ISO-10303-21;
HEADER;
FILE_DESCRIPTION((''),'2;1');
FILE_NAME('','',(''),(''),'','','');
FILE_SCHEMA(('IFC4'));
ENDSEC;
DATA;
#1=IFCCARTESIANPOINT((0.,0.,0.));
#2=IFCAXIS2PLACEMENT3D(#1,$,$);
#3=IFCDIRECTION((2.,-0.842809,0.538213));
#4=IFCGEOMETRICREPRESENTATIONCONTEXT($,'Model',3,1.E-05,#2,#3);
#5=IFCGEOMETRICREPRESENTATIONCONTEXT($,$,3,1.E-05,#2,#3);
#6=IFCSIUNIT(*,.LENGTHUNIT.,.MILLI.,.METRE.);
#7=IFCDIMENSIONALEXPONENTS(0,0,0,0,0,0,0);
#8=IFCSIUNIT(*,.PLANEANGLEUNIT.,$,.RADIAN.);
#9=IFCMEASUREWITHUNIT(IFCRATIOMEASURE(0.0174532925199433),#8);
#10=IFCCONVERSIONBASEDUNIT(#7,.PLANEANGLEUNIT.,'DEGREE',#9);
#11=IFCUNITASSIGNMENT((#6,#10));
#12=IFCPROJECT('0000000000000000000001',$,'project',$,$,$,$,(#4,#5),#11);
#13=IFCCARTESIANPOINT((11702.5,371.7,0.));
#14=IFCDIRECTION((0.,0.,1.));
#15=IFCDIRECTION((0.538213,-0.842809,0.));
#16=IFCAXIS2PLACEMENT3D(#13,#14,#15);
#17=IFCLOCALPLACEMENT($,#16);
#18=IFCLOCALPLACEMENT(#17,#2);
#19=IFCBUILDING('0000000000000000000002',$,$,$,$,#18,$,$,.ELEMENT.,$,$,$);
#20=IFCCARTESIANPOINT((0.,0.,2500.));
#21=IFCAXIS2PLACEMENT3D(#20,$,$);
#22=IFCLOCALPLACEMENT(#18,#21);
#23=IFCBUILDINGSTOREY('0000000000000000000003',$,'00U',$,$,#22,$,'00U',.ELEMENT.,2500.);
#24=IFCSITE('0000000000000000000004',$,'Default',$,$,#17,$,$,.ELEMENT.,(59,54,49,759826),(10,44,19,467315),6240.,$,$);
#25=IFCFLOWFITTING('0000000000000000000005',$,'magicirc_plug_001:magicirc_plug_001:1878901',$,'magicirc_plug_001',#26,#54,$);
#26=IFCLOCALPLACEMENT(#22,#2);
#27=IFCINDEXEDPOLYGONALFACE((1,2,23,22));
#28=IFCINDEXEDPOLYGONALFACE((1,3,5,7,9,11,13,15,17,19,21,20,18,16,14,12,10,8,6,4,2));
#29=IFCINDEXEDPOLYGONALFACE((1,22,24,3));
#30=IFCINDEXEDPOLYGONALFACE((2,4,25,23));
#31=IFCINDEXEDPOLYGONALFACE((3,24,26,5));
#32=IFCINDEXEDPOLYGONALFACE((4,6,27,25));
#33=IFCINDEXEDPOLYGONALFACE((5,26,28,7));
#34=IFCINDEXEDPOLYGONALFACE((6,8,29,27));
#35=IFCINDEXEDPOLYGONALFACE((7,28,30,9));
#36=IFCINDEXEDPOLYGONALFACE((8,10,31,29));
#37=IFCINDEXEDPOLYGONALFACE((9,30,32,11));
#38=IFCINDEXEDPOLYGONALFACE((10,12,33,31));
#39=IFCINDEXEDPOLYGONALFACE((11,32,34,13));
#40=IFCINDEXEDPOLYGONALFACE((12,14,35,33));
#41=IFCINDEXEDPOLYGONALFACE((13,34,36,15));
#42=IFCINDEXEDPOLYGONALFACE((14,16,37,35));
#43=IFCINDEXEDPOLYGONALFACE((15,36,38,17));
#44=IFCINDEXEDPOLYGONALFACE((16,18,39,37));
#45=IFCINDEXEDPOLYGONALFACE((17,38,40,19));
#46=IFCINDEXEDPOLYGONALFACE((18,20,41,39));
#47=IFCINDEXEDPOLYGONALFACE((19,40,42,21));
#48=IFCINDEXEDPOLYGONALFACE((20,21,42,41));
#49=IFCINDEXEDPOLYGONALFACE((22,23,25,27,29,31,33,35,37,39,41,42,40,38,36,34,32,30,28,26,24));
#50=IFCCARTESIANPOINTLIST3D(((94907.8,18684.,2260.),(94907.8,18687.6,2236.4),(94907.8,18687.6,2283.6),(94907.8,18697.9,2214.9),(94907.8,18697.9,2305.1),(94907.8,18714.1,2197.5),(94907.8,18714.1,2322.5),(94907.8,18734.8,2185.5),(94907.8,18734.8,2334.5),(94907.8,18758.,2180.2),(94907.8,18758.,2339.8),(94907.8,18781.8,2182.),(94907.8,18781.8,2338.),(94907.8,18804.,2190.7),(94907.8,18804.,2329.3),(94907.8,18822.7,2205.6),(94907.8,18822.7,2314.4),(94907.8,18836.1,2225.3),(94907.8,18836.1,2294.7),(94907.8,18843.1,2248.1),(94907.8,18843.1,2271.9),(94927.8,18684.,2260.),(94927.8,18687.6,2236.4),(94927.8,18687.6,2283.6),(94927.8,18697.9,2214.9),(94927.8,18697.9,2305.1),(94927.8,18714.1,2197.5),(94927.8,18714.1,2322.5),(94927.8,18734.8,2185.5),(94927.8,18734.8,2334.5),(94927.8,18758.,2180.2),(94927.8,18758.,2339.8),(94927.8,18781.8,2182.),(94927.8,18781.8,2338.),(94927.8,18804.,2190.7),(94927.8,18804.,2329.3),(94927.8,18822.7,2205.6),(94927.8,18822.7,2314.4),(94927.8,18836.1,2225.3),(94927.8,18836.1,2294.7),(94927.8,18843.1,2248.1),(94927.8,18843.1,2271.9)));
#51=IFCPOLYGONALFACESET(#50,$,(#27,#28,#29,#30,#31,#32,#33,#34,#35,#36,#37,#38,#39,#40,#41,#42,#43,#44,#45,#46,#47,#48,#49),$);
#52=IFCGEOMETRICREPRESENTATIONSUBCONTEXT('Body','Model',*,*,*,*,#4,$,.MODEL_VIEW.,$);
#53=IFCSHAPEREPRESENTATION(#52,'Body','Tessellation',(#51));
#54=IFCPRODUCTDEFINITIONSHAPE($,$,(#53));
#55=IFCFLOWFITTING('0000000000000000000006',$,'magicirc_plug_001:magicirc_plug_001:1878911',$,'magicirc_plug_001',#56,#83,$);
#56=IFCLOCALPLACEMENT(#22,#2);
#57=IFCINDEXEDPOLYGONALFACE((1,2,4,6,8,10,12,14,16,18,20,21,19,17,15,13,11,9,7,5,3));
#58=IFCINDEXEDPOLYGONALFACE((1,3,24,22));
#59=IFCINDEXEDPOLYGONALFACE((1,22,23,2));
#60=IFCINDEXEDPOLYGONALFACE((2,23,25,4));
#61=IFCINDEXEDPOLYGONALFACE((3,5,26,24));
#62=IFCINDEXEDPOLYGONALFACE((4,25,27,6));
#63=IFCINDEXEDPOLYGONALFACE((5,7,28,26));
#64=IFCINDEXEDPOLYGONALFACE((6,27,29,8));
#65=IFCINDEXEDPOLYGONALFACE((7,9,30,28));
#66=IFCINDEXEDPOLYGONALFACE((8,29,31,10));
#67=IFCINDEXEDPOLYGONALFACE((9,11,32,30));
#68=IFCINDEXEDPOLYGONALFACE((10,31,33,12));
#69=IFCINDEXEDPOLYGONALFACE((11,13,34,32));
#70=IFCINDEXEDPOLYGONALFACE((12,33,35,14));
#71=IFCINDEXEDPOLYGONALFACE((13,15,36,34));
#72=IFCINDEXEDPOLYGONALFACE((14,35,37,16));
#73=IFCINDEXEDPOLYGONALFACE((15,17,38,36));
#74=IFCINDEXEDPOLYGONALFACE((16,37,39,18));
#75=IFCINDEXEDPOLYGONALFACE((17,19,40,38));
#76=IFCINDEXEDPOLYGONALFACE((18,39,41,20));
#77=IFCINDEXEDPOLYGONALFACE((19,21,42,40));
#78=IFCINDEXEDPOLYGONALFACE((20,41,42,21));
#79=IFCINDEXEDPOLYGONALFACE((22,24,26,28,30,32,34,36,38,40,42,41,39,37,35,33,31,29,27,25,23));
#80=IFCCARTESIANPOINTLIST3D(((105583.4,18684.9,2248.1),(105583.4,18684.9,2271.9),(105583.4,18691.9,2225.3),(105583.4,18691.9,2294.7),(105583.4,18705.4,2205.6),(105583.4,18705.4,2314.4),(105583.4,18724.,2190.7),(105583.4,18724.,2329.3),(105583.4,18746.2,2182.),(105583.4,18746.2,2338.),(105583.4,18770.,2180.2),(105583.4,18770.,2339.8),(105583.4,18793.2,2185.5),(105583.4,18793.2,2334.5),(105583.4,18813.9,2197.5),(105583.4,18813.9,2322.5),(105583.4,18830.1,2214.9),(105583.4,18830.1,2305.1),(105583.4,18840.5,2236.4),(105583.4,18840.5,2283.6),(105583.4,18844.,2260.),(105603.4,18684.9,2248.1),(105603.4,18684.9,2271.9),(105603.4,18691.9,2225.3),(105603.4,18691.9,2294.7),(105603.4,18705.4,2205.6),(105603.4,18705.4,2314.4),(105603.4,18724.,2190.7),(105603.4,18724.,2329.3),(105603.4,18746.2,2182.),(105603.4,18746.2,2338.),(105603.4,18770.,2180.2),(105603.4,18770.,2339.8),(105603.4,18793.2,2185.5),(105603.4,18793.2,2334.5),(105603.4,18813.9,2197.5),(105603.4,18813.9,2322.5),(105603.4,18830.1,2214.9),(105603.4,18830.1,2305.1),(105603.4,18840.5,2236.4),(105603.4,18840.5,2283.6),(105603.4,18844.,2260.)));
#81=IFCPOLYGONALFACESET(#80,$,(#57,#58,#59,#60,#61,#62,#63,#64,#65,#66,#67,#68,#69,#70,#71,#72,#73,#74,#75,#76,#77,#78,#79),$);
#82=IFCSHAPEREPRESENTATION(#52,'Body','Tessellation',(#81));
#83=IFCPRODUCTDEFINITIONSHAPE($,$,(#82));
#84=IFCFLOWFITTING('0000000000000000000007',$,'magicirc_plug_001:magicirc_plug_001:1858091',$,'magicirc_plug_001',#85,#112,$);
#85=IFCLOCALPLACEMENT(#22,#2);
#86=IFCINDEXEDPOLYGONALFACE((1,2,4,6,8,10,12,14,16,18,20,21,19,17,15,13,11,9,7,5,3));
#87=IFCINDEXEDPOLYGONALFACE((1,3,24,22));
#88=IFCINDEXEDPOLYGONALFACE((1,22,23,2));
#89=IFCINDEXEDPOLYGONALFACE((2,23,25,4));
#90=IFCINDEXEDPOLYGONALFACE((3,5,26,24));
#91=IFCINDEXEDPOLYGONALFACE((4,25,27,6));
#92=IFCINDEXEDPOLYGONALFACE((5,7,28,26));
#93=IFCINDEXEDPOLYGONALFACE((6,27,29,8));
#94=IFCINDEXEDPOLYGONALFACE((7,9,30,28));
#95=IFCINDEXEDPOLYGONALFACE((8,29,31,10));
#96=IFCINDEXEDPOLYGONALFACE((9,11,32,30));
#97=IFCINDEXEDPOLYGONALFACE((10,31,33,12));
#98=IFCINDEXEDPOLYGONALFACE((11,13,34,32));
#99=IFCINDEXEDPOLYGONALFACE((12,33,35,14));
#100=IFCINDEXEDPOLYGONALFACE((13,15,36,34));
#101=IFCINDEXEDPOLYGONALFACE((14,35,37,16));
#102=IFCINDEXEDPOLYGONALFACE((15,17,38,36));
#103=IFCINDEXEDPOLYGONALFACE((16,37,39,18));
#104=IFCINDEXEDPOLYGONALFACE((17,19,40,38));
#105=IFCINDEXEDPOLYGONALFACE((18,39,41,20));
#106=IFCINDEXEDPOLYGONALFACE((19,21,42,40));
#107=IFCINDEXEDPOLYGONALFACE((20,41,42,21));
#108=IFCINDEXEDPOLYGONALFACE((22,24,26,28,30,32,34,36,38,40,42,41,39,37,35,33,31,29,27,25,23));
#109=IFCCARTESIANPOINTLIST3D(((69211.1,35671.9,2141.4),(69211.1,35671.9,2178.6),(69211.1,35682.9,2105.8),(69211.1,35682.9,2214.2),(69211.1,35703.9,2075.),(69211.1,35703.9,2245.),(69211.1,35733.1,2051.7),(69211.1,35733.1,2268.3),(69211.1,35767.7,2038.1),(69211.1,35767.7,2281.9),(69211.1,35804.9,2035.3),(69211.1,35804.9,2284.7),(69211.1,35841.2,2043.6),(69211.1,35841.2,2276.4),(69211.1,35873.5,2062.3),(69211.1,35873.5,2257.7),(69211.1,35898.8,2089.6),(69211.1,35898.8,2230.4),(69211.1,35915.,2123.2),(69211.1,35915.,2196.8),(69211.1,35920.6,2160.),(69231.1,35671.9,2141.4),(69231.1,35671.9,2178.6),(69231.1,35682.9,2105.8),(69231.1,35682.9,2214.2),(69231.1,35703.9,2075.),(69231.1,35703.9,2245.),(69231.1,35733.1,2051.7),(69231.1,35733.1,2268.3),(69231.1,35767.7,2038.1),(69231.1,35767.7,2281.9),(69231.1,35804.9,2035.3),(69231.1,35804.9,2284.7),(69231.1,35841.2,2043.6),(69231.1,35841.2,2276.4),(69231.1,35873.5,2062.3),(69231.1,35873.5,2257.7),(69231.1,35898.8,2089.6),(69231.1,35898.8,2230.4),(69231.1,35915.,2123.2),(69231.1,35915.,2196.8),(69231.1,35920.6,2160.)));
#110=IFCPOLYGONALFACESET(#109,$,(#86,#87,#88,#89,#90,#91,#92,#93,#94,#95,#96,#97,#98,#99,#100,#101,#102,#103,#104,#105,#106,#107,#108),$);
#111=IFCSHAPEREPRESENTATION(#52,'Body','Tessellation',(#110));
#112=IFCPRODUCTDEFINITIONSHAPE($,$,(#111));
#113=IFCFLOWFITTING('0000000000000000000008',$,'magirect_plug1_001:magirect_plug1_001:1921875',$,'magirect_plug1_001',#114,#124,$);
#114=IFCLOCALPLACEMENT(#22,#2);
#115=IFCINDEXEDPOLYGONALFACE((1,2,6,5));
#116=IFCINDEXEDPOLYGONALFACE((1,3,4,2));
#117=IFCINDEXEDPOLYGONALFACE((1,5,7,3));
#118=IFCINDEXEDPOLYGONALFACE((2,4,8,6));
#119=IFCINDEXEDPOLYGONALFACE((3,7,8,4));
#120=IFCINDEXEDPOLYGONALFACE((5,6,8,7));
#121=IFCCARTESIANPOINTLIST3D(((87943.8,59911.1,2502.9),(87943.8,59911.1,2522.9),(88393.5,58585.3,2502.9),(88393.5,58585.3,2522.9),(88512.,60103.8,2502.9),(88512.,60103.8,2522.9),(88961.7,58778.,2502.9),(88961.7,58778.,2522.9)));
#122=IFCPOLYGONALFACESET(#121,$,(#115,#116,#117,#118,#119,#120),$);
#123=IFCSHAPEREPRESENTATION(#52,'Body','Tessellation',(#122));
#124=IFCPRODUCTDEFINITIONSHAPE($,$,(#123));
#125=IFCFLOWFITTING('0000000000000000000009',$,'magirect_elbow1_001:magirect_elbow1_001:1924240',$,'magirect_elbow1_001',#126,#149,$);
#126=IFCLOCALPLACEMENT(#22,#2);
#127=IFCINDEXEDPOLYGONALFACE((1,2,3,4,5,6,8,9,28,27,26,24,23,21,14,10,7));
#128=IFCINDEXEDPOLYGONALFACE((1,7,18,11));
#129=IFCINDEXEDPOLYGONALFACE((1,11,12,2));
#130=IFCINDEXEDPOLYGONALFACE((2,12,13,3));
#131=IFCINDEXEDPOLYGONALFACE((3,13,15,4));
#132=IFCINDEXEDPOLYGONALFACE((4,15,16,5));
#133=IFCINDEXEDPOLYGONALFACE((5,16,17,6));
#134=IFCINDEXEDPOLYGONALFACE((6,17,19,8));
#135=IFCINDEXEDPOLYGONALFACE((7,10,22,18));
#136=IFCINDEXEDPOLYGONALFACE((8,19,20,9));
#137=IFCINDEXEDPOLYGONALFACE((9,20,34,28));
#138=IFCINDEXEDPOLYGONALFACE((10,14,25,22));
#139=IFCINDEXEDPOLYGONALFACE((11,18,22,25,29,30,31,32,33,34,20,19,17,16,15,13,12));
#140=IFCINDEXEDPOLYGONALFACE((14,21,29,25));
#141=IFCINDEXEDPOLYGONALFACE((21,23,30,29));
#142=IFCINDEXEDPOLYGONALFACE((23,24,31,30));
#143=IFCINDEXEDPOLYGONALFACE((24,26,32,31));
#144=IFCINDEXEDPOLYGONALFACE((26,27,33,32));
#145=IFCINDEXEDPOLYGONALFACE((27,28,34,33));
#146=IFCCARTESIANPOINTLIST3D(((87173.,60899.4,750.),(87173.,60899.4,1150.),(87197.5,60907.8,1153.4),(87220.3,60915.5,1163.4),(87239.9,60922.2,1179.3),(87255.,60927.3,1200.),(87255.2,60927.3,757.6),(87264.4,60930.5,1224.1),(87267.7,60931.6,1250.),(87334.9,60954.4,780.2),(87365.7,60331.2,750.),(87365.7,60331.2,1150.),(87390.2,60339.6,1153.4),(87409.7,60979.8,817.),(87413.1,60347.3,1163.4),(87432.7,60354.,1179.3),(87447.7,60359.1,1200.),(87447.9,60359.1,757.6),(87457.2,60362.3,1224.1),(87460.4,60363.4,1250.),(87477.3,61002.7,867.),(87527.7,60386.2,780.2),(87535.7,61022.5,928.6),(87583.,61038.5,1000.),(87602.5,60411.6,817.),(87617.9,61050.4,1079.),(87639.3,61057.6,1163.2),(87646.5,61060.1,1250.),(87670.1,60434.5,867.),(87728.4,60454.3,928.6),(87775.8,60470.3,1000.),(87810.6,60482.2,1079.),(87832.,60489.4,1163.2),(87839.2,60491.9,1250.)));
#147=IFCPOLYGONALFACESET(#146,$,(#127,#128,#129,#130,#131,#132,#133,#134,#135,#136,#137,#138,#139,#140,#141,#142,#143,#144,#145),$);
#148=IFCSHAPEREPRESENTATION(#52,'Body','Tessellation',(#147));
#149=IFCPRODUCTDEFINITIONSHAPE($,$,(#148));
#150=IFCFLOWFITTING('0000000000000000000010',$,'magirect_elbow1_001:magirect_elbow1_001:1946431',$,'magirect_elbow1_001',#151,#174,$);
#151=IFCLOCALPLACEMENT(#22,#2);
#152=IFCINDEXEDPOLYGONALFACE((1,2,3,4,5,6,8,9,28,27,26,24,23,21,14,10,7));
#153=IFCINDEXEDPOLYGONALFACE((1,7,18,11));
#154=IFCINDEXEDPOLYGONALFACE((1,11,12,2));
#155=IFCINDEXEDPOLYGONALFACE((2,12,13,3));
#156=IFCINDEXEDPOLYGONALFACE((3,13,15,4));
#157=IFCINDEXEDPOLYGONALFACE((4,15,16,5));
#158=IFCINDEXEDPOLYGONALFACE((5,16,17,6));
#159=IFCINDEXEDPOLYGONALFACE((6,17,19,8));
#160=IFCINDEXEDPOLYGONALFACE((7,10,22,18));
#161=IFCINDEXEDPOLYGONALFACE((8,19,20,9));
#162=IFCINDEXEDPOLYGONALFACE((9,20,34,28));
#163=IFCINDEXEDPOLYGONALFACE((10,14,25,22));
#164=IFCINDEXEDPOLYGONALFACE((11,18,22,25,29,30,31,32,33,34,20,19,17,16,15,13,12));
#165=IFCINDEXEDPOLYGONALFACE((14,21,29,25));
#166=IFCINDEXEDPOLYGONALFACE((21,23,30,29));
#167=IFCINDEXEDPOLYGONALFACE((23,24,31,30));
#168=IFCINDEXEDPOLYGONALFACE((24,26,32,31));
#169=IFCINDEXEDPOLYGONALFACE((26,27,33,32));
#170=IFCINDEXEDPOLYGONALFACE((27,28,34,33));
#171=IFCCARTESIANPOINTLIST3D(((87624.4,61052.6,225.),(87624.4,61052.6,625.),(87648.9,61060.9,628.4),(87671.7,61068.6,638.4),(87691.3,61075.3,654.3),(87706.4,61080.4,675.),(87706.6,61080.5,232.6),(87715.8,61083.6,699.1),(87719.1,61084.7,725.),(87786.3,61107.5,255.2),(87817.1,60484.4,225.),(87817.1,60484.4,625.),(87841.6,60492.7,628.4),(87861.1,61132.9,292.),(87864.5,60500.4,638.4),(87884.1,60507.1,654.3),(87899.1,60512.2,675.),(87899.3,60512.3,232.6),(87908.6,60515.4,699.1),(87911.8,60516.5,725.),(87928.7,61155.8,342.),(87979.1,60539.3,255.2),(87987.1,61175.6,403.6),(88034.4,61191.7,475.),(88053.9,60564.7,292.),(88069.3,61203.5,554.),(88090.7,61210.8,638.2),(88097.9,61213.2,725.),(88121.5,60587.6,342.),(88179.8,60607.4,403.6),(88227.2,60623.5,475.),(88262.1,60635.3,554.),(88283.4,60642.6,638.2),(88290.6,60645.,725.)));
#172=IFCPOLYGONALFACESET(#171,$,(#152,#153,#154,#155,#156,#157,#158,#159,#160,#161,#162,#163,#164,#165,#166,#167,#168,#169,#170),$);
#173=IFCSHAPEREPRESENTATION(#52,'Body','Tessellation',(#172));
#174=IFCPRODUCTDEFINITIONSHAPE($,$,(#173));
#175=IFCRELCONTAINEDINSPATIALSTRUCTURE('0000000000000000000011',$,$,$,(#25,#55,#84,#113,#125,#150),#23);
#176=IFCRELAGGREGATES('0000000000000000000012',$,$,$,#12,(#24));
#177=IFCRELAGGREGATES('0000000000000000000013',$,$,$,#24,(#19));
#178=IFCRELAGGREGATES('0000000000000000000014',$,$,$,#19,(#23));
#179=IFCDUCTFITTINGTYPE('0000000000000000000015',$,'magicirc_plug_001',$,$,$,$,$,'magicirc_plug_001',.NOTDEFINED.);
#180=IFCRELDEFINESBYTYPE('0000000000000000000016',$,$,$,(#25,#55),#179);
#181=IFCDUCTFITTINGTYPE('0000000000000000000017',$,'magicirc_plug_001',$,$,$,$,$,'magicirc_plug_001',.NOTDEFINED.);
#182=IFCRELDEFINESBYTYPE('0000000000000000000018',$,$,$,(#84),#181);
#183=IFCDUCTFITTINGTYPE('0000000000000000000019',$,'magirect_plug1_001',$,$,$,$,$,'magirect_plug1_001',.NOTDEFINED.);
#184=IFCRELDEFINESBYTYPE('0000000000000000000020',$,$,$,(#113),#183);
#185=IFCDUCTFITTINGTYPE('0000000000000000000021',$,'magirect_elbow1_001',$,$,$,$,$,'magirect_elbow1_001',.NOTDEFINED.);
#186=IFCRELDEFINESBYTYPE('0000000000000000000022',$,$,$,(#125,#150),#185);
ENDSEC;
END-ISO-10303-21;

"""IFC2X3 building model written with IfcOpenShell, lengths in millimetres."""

from ifc_helpers import new_model, entity, si_unit, converted_unit, direction, frame, frame_2d, origin, place, context, subcontext, project, spatial, polyline, circle_curve, parameter, trimmed, segment, composite_curve, rectangle, circle, outline, extrude, source, transform, mapped, type_object, type_shapes, element, save


model = new_model("IFC2X3")

# Units and contexts
model_context = context("Model", 3, precision=1e-05, world=origin(), true_north=direction((2.0, -0.842809, 0.538213)))
context_of_model = context(None, 3, precision=1e-05, world=origin(), true_north=direction((2.0, -0.842809, 0.538213)))
body_context = subcontext(model_context, "Body", "Model", "MODEL_VIEW")
ifc_project = project(units=[si_unit("LENGTHUNIT", "METRE", prefix="MILLI"), converted_unit("PLANEANGLEUNIT", "DEGREE", entity("IfcRatioMeasure", 0.0174532925199433), si_unit("PLANEANGLEUNIT", "RADIAN"), dimensions=[0, 0, 0, 0, 0, 0, 0])], contexts=[model_context, context_of_model])

# Site, building, storey
site_placement = place(None, frame((11702.5, 371.7, 0.0), z_axis=(0.0, 0.0, 1.0), x_axis=(0.538213, -0.842809, 0.0)))
site = spatial("IfcSite", under=ifc_project, at=site_placement, Name="Default", CompositionType="ELEMENT", RefLatitude=(59, 54, 49, 759826), RefLongitude=(10, 44, 19, 467315), RefElevation=6240.0)
building_placement = place(site_placement, origin())
building = spatial("IfcBuilding", under=site, at=building_placement, CompositionType="ELEMENT")
storey_placement = place(building_placement, frame((0.0, 0.0, 2500.0)))
storey = spatial("IfcBuildingStorey", under=building, at=storey_placement, Name="00U", LongName="00U", CompositionType="ELEMENT", Elevation=2500.0)

# Flow fittings
duct_fitting_type_1 = type_object("IfcDuctFittingType", Name="magicirc_plug_001", ElementType="magicirc_plug_001", PredefinedType="NOTDEFINED")
shared_shape_1 = source(origin(), body_context, "Body", "SweptSolid", [
    extrude(circle(Radius=80.0, at=frame_2d((0.0, 0.0), x_axis=(1.0, 0.0))), frame((0.0, 0.0, 0.0), z_axis=(1.0, 0.0, 0.0), x_axis=(0.0, 1.0, 0.0)), (0.0, 0.0, 1.0), 20.0),
])
type_shapes(duct_fitting_type_1, [shared_shape_1])
flow_fitting_1_placement = place(storey_placement, frame((94927.8, 18764.0, 2260.0), z_axis=(0.0, 0.0, 1.0), x_axis=(-1.0, 0.0, 0.0)))
element("IfcFlowFitting", 1, at=flow_fitting_1_placement, inside=storey, type_object=duct_fitting_type_1, Name="magicirc_plug_001:magicirc_plug_001:1878901", ObjectType="magicirc_plug_001", context=body_context, shape_type="MappedRepresentation", body=[
    mapped(shared_shape_1, transform((0.0, 0.0, 0.0), scale=1.0)),
])
flow_fitting_2_placement = place(storey_placement, frame((105583.4, 18764.0, 2260.0)))
element("IfcFlowFitting", 2, at=flow_fitting_2_placement, inside=storey, type_object=duct_fitting_type_1, Name="magicirc_plug_001:magicirc_plug_001:1878911", ObjectType="magicirc_plug_001", context=body_context, shape_type="MappedRepresentation", body=[
    mapped(shared_shape_1, transform((0.0, 0.0, 0.0), scale=1.0)),
])
duct_fitting_type_2 = type_object("IfcDuctFittingType", Name="magicirc_plug_001", ElementType="magicirc_plug_001", PredefinedType="NOTDEFINED")
shared_shape_2 = source(origin(), body_context, "Body", "SweptSolid", [
    extrude(circle(Radius=125.0, at=frame_2d((0.0, 0.0), x_axis=(1.0, 0.0))), frame((0.0, 0.0, 0.0), z_axis=(1.0, 0.0, 0.0), x_axis=(0.0, 1.0, 0.0)), (0.0, 0.0, 1.0), 20.0),
])
type_shapes(duct_fitting_type_2, [shared_shape_2])
flow_fitting_3_placement = place(storey_placement, frame((69211.1, 35795.6, 2160.0)))
element("IfcFlowFitting", 3, at=flow_fitting_3_placement, inside=storey, type_object=duct_fitting_type_2, Name="magicirc_plug_001:magicirc_plug_001:1858091", ObjectType="magicirc_plug_001", context=body_context, shape_type="MappedRepresentation", body=[
    mapped(shared_shape_2, transform((0.0, 0.0, 0.0), scale=1.0)),
])
duct_fitting_type_3 = type_object("IfcDuctFittingType", Name="magirect_plug1_001", ElementType="magirect_plug1_001", PredefinedType="NOTDEFINED")
shared_shape_3 = source(origin(), body_context, "Body", "SweptSolid", [
    extrude(rectangle(XDim=20.0, YDim=1400.0, at=frame_2d((0.0, 0.0), x_axis=(1.0, 0.0))), frame((10.0, 0.0, -300.0)), (0.0, 0.0, 1.0), 600.0),
])
type_shapes(duct_fitting_type_3, [shared_shape_3])
flow_fitting_4_placement = place(storey_placement, frame((88452.8, 59344.5, 2502.9), z_axis=(-0.946996, -0.321246, 0.0), x_axis=(0.0, 0.0, 1.0)))
element("IfcFlowFitting", 4, at=flow_fitting_4_placement, inside=storey, type_object=duct_fitting_type_3, Name="magirect_plug1_001:magirect_plug1_001:1921875", ObjectType="magirect_plug1_001", context=body_context, shape_type="MappedRepresentation", body=[
    mapped(shared_shape_3, transform((0.0, 0.0, 0.0), scale=1.0)),
])
duct_fitting_type_4 = type_object("IfcDuctFittingType", Name="magirect_elbow1_001", ElementType="magirect_elbow1_001", PredefinedType="NOTDEFINED")
shared_shape_4 = source(origin(), body_context, "Body", "SweptSolid", [
    extrude(outline(composite_curve([segment(polyline([(-350.0, -150.0), (50.0, -150.0)]), True, "CONTINUOUS"), segment(trimmed(circle_curve(frame_2d((150.0, -150.0), x_axis=(0.0, 1.0)), 100.0), [parameter(0.0)], [parameter(90.0)], True, "PARAMETER"), False, "CONTINUOUS"), segment(polyline([(150.0, -50.0), (150.0, 350.0)]), True, "CONTINUOUS"), segment(trimmed(circle_curve(frame_2d((150.0, -150.0), x_axis=(0.0, 1.0)), 500.0), [parameter(0.0)], [parameter(90.0)], True, "PARAMETER"), True, "CONTINUOUS")], self_intersect=False)), frame((-150.0, 150.0, -300.0), z_axis=(0.0, 0.0, 1.0), x_axis=(-1.0, 0.0, 0.0)), (0.0, 0.0, 1.0), 600.0),
])
type_shapes(duct_fitting_type_4, [shared_shape_4])
for number, where, z_axis, x_axis, name in (
    (5, (87553.4, 60711.7, 950.0), (-0.321246, 0.946996, 0.0), (0.0, 0.0, -1.0), "magirect_elbow1_001:magirect_elbow1_001:1924240"),
    (6, (88004.8, 60864.8, 425.0), (-0.321246, 0.946996, 0.0), (0.0, 0.0, -1.0), "magirect_elbow1_001:magirect_elbow1_001:1946431"),
):
    element("IfcFlowFitting", number, at=place(storey_placement, frame(where, z_axis=z_axis, x_axis=x_axis)), inside=storey, type_object=duct_fitting_type_4, Name=name, ObjectType="magirect_elbow1_001", context=body_context, shape_type="MappedRepresentation", body=[
        mapped(shared_shape_4, transform((0.0, 0.0, 0.0), scale=1.0)),
    ])

save(model, "model.ifc")
